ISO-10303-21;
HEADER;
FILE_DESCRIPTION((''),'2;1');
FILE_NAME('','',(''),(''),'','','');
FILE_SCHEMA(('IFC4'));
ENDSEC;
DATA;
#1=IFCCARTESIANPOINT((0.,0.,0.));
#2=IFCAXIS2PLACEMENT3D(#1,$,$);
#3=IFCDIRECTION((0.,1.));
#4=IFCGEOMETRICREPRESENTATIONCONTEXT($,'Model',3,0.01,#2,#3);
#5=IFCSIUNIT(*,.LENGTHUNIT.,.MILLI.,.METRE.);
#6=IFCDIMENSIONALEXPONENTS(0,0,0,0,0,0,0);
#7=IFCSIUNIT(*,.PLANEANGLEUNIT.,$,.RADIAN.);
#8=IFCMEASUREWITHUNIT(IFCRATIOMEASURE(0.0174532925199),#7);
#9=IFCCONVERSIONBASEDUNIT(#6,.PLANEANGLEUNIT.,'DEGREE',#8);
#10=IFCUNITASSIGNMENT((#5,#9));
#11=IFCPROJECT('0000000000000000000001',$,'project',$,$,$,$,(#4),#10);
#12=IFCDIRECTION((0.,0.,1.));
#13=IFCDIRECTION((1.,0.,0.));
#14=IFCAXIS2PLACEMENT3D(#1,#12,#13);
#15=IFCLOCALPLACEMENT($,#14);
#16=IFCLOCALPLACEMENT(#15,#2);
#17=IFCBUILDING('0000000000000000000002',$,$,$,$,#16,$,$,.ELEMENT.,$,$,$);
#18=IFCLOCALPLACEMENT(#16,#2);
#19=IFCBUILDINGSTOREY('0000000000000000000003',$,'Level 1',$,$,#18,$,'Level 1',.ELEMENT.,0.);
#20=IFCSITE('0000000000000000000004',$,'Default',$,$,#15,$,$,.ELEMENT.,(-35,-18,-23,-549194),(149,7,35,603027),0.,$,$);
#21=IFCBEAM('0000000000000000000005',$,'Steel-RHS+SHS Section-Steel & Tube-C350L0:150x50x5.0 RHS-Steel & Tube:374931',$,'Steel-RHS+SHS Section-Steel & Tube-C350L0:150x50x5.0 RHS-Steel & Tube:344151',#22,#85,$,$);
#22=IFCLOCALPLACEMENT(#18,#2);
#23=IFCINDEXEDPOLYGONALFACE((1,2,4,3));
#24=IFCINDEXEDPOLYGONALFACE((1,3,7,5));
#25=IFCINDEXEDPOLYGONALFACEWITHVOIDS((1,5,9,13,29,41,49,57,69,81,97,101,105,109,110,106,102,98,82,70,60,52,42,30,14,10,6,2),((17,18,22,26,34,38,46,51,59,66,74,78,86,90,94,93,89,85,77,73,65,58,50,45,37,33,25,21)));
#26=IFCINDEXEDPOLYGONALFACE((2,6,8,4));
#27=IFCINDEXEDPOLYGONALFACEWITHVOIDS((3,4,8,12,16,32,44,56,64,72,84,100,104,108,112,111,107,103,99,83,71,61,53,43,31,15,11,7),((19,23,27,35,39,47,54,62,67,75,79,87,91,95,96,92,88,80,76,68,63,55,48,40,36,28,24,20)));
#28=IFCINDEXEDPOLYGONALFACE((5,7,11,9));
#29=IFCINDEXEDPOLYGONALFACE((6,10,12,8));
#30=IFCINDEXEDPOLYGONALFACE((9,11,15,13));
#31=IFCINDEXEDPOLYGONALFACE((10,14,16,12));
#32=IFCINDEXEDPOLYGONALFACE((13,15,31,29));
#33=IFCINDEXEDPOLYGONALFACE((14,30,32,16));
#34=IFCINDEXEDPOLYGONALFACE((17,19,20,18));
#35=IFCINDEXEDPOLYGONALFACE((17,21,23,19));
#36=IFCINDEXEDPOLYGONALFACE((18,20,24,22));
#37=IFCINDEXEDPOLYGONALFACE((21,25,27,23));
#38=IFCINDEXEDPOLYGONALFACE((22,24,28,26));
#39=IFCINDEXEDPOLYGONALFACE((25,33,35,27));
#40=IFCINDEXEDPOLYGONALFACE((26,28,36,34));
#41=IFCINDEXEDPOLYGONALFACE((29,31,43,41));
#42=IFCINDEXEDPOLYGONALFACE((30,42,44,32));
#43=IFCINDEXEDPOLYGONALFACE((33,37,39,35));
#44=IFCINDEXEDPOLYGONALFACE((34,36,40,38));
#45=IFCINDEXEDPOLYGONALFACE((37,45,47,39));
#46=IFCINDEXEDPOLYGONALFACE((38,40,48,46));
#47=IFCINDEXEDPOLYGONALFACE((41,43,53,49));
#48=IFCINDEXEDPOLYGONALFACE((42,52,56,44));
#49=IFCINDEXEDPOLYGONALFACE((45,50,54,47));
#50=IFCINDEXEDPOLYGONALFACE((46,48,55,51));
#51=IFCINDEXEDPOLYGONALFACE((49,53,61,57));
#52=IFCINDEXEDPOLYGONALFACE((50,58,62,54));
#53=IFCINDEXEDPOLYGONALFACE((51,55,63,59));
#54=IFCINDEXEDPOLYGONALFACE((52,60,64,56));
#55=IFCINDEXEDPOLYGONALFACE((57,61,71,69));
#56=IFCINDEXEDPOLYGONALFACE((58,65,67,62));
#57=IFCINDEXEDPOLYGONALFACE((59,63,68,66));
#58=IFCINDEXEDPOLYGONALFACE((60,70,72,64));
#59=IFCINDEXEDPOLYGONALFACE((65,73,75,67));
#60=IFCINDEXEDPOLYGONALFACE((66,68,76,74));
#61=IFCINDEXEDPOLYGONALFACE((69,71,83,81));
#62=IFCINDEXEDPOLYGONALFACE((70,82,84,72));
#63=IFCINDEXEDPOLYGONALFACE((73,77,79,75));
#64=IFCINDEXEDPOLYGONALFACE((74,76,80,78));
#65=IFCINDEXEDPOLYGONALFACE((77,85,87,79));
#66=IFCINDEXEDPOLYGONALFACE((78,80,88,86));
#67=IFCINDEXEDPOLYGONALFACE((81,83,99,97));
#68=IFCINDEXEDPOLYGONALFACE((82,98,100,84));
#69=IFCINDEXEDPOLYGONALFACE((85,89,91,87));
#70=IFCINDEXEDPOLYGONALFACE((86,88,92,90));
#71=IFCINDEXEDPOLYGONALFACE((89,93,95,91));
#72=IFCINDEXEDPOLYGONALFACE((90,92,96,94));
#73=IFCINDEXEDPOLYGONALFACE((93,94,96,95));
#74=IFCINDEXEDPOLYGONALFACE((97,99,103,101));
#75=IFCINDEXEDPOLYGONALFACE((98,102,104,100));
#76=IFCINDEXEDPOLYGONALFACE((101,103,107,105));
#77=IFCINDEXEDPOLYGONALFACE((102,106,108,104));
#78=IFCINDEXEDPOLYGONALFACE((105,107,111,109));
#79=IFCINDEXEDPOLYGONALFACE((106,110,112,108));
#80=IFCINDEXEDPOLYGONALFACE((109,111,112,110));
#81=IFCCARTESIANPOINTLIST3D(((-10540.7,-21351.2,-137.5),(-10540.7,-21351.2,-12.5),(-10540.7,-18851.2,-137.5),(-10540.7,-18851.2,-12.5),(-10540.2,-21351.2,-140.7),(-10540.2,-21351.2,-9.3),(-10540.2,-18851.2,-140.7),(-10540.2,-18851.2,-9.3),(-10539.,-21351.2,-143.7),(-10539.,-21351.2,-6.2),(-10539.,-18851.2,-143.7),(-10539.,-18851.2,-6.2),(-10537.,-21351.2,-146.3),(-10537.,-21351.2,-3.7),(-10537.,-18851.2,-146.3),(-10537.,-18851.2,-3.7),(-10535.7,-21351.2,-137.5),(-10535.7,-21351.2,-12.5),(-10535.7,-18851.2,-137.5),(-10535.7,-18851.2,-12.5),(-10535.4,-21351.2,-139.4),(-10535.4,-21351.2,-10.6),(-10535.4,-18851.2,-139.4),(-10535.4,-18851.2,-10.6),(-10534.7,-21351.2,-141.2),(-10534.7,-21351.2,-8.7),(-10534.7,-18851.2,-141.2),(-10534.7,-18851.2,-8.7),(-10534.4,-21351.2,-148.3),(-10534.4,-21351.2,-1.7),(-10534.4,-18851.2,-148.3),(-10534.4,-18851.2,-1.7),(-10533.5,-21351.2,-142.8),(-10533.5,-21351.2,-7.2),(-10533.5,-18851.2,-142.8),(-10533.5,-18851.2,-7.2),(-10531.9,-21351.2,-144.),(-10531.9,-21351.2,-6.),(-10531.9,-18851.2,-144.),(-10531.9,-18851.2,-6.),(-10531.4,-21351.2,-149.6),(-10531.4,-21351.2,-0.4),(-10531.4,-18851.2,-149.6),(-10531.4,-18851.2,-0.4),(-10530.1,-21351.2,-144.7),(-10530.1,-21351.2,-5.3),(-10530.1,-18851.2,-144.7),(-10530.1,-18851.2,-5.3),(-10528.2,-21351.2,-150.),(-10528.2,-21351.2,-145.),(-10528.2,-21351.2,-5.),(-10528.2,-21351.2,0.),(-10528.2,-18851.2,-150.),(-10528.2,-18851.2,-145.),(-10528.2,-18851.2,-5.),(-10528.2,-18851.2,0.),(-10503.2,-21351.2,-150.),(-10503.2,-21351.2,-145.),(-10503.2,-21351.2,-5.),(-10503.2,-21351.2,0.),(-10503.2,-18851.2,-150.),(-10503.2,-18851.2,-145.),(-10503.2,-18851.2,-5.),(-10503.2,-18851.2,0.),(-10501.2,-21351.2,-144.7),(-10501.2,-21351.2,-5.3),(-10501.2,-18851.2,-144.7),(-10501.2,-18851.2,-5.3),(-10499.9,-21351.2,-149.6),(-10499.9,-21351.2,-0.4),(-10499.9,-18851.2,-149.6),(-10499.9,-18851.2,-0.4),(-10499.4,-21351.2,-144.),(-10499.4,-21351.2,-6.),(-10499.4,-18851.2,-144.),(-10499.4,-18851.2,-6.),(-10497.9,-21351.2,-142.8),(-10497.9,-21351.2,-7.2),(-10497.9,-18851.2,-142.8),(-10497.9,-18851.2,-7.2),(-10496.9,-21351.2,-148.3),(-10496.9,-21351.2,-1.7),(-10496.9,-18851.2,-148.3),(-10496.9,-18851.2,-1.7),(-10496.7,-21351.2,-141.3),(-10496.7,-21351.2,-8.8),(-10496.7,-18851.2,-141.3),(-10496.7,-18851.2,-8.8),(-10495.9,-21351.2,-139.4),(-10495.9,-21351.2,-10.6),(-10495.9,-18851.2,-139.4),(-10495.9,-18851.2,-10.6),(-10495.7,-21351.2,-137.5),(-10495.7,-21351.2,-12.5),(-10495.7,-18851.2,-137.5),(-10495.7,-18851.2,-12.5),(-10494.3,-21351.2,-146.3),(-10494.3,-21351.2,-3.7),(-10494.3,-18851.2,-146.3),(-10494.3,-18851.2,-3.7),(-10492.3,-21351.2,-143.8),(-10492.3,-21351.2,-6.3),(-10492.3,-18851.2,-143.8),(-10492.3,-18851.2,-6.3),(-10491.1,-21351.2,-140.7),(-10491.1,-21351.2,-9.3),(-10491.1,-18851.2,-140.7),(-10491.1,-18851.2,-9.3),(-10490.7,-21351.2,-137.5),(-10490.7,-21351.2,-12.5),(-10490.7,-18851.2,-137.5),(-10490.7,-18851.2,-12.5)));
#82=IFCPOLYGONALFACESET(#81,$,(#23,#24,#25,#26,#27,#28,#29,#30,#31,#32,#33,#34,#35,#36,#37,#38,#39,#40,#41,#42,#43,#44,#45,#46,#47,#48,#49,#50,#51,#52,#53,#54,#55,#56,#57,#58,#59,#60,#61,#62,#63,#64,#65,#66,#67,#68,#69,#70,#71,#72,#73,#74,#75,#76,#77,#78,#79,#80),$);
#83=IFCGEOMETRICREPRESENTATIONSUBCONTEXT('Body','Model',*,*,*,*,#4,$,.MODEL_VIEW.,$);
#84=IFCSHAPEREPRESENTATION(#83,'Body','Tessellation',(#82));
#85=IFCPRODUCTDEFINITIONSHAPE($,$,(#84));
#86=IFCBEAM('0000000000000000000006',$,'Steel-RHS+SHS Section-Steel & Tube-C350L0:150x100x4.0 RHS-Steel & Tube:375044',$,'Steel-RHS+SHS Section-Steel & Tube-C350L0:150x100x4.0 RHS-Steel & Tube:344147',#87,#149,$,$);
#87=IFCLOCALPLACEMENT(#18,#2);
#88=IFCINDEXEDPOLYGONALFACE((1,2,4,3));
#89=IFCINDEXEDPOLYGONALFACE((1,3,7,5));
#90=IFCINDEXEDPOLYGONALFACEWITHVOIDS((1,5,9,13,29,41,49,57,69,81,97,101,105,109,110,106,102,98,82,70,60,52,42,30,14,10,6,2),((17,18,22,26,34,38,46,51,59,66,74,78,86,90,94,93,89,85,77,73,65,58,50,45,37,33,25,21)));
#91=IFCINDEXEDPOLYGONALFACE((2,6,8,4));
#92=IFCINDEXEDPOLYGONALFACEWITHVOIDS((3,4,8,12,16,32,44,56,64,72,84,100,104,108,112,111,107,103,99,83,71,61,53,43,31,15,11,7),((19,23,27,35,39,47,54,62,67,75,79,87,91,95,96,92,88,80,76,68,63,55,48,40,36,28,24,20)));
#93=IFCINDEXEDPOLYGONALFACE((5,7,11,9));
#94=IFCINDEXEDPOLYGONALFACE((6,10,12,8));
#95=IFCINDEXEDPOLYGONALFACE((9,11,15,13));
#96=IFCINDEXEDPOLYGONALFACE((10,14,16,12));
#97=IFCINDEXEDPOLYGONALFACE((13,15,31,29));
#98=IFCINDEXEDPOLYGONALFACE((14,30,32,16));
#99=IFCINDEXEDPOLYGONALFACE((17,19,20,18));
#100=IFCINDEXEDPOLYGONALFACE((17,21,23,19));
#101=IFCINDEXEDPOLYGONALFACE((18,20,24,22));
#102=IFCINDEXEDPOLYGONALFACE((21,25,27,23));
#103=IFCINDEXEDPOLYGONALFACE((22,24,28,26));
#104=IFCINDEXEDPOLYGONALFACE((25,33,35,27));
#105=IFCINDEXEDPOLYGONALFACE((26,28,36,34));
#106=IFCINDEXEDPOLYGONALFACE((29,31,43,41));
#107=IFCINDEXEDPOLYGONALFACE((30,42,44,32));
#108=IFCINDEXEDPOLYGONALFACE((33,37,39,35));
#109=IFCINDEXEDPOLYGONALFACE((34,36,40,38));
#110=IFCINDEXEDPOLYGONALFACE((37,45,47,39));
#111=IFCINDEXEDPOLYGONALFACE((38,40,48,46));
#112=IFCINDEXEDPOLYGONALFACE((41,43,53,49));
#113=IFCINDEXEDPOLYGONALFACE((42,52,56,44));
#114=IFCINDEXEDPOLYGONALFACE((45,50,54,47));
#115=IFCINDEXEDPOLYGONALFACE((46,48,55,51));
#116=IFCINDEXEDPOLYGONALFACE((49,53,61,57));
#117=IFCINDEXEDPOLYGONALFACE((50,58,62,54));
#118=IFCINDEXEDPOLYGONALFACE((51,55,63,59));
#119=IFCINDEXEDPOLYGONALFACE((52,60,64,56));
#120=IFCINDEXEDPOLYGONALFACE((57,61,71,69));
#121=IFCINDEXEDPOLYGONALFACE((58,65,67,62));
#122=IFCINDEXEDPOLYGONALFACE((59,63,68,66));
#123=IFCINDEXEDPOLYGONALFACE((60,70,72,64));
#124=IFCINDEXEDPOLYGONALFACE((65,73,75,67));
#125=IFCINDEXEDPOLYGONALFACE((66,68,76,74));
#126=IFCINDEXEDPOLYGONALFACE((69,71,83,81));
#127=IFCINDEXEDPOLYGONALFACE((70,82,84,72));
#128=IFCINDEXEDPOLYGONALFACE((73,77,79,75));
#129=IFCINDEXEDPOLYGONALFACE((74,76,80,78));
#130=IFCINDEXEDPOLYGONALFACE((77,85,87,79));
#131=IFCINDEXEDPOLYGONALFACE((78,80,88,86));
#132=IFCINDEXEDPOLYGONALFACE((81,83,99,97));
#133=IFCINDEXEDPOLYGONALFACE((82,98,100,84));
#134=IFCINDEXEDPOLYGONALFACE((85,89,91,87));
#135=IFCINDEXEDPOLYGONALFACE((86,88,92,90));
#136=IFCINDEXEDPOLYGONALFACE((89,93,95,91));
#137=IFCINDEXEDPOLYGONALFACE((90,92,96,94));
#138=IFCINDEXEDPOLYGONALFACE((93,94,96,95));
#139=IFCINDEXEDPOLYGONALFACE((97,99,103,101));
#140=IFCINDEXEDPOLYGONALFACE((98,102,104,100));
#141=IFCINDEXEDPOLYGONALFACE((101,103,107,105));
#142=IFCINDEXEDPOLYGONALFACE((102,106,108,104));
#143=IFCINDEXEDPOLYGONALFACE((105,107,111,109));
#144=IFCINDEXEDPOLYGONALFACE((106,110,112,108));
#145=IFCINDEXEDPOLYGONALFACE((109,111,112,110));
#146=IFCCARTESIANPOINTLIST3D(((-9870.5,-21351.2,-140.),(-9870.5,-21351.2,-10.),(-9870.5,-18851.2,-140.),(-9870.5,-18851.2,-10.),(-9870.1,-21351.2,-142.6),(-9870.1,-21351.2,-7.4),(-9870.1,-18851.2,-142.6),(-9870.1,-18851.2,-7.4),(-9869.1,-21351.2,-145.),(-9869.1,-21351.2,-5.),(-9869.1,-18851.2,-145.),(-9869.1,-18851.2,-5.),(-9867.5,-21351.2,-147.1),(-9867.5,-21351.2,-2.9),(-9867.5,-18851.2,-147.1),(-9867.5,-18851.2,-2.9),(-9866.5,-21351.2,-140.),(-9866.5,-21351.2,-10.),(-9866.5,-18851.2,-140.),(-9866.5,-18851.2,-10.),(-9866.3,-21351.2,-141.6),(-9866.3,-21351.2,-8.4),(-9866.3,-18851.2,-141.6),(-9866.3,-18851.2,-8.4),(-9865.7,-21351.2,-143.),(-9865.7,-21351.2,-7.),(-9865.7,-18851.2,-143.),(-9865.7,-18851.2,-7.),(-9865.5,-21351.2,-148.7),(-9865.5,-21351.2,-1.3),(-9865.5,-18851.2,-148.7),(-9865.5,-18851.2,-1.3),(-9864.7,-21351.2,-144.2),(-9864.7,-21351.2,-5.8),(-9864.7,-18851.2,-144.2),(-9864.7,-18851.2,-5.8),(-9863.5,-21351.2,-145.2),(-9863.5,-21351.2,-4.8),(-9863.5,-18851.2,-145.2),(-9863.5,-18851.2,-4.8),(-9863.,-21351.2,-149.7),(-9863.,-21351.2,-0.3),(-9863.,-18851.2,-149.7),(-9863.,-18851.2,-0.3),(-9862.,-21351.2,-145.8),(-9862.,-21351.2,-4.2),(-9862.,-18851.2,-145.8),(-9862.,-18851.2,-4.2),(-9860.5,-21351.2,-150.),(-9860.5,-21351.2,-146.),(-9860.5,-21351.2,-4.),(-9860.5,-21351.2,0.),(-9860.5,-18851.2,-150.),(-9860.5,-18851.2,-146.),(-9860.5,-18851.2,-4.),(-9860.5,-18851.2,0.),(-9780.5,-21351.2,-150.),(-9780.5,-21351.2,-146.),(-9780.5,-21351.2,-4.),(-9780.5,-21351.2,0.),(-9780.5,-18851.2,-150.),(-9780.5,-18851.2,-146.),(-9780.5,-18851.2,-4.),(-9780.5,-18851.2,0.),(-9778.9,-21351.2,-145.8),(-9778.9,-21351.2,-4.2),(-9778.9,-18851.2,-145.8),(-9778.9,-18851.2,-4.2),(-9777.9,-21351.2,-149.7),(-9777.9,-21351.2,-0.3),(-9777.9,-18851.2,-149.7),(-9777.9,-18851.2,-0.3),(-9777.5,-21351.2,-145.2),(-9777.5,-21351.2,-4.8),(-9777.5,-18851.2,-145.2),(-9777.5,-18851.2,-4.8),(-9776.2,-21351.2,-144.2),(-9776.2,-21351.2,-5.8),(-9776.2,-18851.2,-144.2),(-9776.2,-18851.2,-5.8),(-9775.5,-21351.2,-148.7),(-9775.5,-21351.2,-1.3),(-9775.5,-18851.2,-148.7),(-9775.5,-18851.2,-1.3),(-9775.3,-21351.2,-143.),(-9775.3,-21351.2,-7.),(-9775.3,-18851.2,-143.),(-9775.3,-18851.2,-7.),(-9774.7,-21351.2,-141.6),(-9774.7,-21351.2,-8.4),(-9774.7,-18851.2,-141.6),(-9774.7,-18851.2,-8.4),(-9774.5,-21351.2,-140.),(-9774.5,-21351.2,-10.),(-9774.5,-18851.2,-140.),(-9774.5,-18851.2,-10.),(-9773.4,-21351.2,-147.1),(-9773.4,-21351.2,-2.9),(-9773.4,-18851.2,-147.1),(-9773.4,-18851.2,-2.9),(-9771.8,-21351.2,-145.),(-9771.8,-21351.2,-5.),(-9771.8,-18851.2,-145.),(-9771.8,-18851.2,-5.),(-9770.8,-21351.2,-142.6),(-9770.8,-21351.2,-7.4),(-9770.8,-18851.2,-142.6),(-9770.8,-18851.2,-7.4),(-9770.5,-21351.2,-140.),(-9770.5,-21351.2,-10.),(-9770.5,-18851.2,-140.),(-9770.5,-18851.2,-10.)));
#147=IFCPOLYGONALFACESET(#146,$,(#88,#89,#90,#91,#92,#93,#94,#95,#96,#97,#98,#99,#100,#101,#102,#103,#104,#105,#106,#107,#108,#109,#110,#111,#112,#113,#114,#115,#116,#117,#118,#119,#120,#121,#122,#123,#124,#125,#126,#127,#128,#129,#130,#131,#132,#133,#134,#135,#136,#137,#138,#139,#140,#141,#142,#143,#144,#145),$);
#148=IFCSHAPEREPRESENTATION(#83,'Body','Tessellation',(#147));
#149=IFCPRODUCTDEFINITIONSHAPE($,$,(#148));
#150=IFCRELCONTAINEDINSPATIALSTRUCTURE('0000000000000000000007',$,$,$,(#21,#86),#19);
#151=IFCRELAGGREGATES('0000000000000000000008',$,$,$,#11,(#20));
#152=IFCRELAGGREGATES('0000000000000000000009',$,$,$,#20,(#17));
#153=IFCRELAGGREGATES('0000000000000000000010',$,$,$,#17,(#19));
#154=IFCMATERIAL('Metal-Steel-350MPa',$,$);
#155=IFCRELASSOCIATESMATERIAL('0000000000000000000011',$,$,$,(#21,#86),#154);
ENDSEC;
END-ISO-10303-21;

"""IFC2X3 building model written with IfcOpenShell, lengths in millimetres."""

from ifc_helpers import new_model, entity, si_unit, converted_unit, direction, frame, frame_2d, origin, origin_with_axes, place, context, subcontext, project, spatial, polyline, circle_curve, parameter, trimmed, segment, composite_curve, outline, extrude, material, element, save


model = new_model("IFC2X3")

# Units and contexts
model_context = context("Model", 3, precision=0.01, world=origin(), true_north=direction((0.0, 1.0)))
body_context = subcontext(model_context, "Body", "Model", "MODEL_VIEW")
ifc_project = project(units=[si_unit("LENGTHUNIT", "METRE", prefix="MILLI"), converted_unit("PLANEANGLEUNIT", "DEGREE", entity("IfcRatioMeasure", 0.0174532925199), si_unit("PLANEANGLEUNIT", "RADIAN"), dimensions=[0, 0, 0, 0, 0, 0, 0])], contexts=[model_context])

# Site, building, storey
site_placement = place(None, origin_with_axes())
site = spatial("IfcSite", under=ifc_project, at=site_placement, Name="Default", CompositionType="ELEMENT", RefLatitude=(-35, -18, -23, -549194), RefLongitude=(149, 7, 35, 603027), RefElevation=0.0)
building_placement = place(site_placement, origin())
building = spatial("IfcBuilding", under=site, at=building_placement, CompositionType="ELEMENT")
storey_placement = place(building_placement, origin())
storey = spatial("IfcBuildingStorey", under=building, at=storey_placement, Name="Level 1", LongName="Level 1", CompositionType="ELEMENT", Elevation=0.0)

# Beams
ifc_material = material(Name="Metal-Steel-350MPa")
beam_1_placement = place(storey_placement, frame((-10515.7, -18851.2, 0.0), z_axis=(0.0, 0.0, 1.0), x_axis=(0.0, -1.0, 0.0)))
element("IfcBeam", 1, at=beam_1_placement, inside=storey, material=ifc_material, Name="Steel-RHS+SHS Section-Steel & Tube-C350L0:150x50x5.0 RHS-Steel & Tube:374931", ObjectType="Steel-RHS+SHS Section-Steel & Tube-C350L0:150x50x5.0 RHS-Steel & Tube:344151", context=body_context, shape_type="SweptSolid", body=[
    extrude(outline(composite_curve([segment(trimmed(circle_curve(frame_2d((-12.5, -62.5), x_axis=(1.0, 0.0)), 12.5), [parameter(180.0)], [parameter(270.0)], True, "PARAMETER"), True, "CONTINUOUS"), segment(polyline([(-12.5, -75.0), (12.5, -75.0)]), True, "CONTINUOUS"), segment(trimmed(circle_curve(frame_2d((12.5, -62.5), x_axis=(1.0, 0.0)), 12.5), [parameter(270.0)], [parameter(0.0)], True, "PARAMETER"), True, "CONTINUOUS"), segment(polyline([(25.0, -62.5), (25.0, 62.5)]), True, "CONTINUOUS"), segment(trimmed(circle_curve(frame_2d((12.5, 62.5), x_axis=(1.0, 0.0)), 12.5), [parameter(0.0)], [parameter(90.0)], True, "PARAMETER"), True, "CONTINUOUS"), segment(polyline([(12.5, 75.0), (-12.5, 75.0)]), True, "CONTINUOUS"), segment(trimmed(circle_curve(frame_2d((-12.5, 62.5), x_axis=(1.0, 0.0)), 12.5), [parameter(90.0)], [parameter(180.0)], True, "PARAMETER"), True, "CONTINUOUS"), segment(polyline([(-25.0, 62.5), (-25.0, -62.5)]), True, "CONTINUOUS")], self_intersect=False), holes=[composite_curve([segment(polyline([(12.5, -70.0), (-12.5, -70.0)]), True, "CONTINUOUS"), segment(trimmed(circle_curve(frame_2d((-12.5, -62.5), x_axis=(1.0, 0.0)), 7.5), [parameter(180.0)], [parameter(270.0)], True, "PARAMETER"), False, "CONTINUOUS"), segment(polyline([(-20.0, -62.5), (-20.0, 62.5)]), True, "CONTINUOUS"), segment(trimmed(circle_curve(frame_2d((-12.5, 62.5), x_axis=(1.0, 0.0)), 7.5), [parameter(90.0)], [parameter(180.0)], True, "PARAMETER"), False, "CONTINUOUS"), segment(polyline([(-12.5, 70.0), (12.5, 70.0)]), True, "CONTINUOUS"), segment(trimmed(circle_curve(frame_2d((12.5, 62.5), x_axis=(1.0, 0.0)), 7.5), [parameter(360.0)], [parameter(90.0)], True, "PARAMETER"), False, "CONTINUOUS"), segment(polyline([(20.0, 62.5), (20.0, -62.5)]), True, "CONTINUOUS"), segment(trimmed(circle_curve(frame_2d((12.5, -62.5), x_axis=(1.0, 0.0)), 7.5), [parameter(270.0)], [parameter(0.0)], True, "PARAMETER"), False, "CONTINUOUS")], self_intersect=False)]), frame((0.0, 0.0, -75.0), z_axis=(1.0, 0.0, 0.0), x_axis=(0.0, -1.0, 0.0)), (0.0, 0.0, 1.0), 2500.0),
])
beam_2_placement = place(storey_placement, frame((-9820.5, -18851.2, 0.0), z_axis=(0.0, 0.0, 1.0), x_axis=(0.0, -1.0, 0.0)))
element("IfcBeam", 2, at=beam_2_placement, inside=storey, material=ifc_material, Name="Steel-RHS+SHS Section-Steel & Tube-C350L0:150x100x4.0 RHS-Steel & Tube:375044", ObjectType="Steel-RHS+SHS Section-Steel & Tube-C350L0:150x100x4.0 RHS-Steel & Tube:344147", context=body_context, shape_type="SweptSolid", body=[
    extrude(outline(composite_curve([segment(trimmed(circle_curve(frame_2d((-40.0, -65.0), x_axis=(1.0, 0.0)), 10.0), [parameter(180.0)], [parameter(270.0)], True, "PARAMETER"), True, "CONTINUOUS"), segment(polyline([(-40.0, -75.0), (40.0, -75.0)]), True, "CONTINUOUS"), segment(trimmed(circle_curve(frame_2d((40.0, -65.0), x_axis=(1.0, 0.0)), 10.0), [parameter(270.0)], [parameter(0.0)], True, "PARAMETER"), True, "CONTINUOUS"), segment(polyline([(50.0, -65.0), (50.0, 65.0)]), True, "CONTINUOUS"), segment(trimmed(circle_curve(frame_2d((40.0, 65.0), x_axis=(1.0, 0.0)), 10.0), [parameter(0.0)], [parameter(90.0)], True, "PARAMETER"), True, "CONTINUOUS"), segment(polyline([(40.0, 75.0), (-40.0, 75.0)]), True, "CONTINUOUS"), segment(trimmed(circle_curve(frame_2d((-40.0, 65.0), x_axis=(1.0, 0.0)), 10.0), [parameter(90.0)], [parameter(180.0)], True, "PARAMETER"), True, "CONTINUOUS"), segment(polyline([(-50.0, 65.0), (-50.0, -65.0)]), True, "CONTINUOUS")], self_intersect=False), holes=[composite_curve([segment(polyline([(40.0, -71.0), (-40.0, -71.0)]), True, "CONTINUOUS"), segment(trimmed(circle_curve(frame_2d((-40.0, -65.0), x_axis=(1.0, 0.0)), 6.0), [parameter(180.0)], [parameter(270.0)], True, "PARAMETER"), False, "CONTINUOUS"), segment(polyline([(-46.0, -65.0), (-46.0, 65.0)]), True, "CONTINUOUS"), segment(trimmed(circle_curve(frame_2d((-40.0, 65.0), x_axis=(1.0, 0.0)), 6.0), [parameter(90.0)], [parameter(180.0)], True, "PARAMETER"), False, "CONTINUOUS"), segment(polyline([(-40.0, 71.0), (40.0, 71.0)]), True, "CONTINUOUS"), segment(trimmed(circle_curve(frame_2d((40.0, 65.0), x_axis=(1.0, 0.0)), 6.0), [parameter(360.0)], [parameter(90.0)], True, "PARAMETER"), False, "CONTINUOUS"), segment(polyline([(46.0, 65.0), (46.0, -65.0)]), True, "CONTINUOUS"), segment(trimmed(circle_curve(frame_2d((40.0, -65.0), x_axis=(1.0, 0.0)), 6.0), [parameter(270.0)], [parameter(0.0)], True, "PARAMETER"), False, "CONTINUOUS")], self_intersect=False)]), frame((0.0, 0.0, -75.0), z_axis=(1.0, 0.0, 0.0), x_axis=(0.0, -1.0, 0.0)), (0.0, 0.0, 1.0), 2500.0),
])

save(model, "model.ifc")
